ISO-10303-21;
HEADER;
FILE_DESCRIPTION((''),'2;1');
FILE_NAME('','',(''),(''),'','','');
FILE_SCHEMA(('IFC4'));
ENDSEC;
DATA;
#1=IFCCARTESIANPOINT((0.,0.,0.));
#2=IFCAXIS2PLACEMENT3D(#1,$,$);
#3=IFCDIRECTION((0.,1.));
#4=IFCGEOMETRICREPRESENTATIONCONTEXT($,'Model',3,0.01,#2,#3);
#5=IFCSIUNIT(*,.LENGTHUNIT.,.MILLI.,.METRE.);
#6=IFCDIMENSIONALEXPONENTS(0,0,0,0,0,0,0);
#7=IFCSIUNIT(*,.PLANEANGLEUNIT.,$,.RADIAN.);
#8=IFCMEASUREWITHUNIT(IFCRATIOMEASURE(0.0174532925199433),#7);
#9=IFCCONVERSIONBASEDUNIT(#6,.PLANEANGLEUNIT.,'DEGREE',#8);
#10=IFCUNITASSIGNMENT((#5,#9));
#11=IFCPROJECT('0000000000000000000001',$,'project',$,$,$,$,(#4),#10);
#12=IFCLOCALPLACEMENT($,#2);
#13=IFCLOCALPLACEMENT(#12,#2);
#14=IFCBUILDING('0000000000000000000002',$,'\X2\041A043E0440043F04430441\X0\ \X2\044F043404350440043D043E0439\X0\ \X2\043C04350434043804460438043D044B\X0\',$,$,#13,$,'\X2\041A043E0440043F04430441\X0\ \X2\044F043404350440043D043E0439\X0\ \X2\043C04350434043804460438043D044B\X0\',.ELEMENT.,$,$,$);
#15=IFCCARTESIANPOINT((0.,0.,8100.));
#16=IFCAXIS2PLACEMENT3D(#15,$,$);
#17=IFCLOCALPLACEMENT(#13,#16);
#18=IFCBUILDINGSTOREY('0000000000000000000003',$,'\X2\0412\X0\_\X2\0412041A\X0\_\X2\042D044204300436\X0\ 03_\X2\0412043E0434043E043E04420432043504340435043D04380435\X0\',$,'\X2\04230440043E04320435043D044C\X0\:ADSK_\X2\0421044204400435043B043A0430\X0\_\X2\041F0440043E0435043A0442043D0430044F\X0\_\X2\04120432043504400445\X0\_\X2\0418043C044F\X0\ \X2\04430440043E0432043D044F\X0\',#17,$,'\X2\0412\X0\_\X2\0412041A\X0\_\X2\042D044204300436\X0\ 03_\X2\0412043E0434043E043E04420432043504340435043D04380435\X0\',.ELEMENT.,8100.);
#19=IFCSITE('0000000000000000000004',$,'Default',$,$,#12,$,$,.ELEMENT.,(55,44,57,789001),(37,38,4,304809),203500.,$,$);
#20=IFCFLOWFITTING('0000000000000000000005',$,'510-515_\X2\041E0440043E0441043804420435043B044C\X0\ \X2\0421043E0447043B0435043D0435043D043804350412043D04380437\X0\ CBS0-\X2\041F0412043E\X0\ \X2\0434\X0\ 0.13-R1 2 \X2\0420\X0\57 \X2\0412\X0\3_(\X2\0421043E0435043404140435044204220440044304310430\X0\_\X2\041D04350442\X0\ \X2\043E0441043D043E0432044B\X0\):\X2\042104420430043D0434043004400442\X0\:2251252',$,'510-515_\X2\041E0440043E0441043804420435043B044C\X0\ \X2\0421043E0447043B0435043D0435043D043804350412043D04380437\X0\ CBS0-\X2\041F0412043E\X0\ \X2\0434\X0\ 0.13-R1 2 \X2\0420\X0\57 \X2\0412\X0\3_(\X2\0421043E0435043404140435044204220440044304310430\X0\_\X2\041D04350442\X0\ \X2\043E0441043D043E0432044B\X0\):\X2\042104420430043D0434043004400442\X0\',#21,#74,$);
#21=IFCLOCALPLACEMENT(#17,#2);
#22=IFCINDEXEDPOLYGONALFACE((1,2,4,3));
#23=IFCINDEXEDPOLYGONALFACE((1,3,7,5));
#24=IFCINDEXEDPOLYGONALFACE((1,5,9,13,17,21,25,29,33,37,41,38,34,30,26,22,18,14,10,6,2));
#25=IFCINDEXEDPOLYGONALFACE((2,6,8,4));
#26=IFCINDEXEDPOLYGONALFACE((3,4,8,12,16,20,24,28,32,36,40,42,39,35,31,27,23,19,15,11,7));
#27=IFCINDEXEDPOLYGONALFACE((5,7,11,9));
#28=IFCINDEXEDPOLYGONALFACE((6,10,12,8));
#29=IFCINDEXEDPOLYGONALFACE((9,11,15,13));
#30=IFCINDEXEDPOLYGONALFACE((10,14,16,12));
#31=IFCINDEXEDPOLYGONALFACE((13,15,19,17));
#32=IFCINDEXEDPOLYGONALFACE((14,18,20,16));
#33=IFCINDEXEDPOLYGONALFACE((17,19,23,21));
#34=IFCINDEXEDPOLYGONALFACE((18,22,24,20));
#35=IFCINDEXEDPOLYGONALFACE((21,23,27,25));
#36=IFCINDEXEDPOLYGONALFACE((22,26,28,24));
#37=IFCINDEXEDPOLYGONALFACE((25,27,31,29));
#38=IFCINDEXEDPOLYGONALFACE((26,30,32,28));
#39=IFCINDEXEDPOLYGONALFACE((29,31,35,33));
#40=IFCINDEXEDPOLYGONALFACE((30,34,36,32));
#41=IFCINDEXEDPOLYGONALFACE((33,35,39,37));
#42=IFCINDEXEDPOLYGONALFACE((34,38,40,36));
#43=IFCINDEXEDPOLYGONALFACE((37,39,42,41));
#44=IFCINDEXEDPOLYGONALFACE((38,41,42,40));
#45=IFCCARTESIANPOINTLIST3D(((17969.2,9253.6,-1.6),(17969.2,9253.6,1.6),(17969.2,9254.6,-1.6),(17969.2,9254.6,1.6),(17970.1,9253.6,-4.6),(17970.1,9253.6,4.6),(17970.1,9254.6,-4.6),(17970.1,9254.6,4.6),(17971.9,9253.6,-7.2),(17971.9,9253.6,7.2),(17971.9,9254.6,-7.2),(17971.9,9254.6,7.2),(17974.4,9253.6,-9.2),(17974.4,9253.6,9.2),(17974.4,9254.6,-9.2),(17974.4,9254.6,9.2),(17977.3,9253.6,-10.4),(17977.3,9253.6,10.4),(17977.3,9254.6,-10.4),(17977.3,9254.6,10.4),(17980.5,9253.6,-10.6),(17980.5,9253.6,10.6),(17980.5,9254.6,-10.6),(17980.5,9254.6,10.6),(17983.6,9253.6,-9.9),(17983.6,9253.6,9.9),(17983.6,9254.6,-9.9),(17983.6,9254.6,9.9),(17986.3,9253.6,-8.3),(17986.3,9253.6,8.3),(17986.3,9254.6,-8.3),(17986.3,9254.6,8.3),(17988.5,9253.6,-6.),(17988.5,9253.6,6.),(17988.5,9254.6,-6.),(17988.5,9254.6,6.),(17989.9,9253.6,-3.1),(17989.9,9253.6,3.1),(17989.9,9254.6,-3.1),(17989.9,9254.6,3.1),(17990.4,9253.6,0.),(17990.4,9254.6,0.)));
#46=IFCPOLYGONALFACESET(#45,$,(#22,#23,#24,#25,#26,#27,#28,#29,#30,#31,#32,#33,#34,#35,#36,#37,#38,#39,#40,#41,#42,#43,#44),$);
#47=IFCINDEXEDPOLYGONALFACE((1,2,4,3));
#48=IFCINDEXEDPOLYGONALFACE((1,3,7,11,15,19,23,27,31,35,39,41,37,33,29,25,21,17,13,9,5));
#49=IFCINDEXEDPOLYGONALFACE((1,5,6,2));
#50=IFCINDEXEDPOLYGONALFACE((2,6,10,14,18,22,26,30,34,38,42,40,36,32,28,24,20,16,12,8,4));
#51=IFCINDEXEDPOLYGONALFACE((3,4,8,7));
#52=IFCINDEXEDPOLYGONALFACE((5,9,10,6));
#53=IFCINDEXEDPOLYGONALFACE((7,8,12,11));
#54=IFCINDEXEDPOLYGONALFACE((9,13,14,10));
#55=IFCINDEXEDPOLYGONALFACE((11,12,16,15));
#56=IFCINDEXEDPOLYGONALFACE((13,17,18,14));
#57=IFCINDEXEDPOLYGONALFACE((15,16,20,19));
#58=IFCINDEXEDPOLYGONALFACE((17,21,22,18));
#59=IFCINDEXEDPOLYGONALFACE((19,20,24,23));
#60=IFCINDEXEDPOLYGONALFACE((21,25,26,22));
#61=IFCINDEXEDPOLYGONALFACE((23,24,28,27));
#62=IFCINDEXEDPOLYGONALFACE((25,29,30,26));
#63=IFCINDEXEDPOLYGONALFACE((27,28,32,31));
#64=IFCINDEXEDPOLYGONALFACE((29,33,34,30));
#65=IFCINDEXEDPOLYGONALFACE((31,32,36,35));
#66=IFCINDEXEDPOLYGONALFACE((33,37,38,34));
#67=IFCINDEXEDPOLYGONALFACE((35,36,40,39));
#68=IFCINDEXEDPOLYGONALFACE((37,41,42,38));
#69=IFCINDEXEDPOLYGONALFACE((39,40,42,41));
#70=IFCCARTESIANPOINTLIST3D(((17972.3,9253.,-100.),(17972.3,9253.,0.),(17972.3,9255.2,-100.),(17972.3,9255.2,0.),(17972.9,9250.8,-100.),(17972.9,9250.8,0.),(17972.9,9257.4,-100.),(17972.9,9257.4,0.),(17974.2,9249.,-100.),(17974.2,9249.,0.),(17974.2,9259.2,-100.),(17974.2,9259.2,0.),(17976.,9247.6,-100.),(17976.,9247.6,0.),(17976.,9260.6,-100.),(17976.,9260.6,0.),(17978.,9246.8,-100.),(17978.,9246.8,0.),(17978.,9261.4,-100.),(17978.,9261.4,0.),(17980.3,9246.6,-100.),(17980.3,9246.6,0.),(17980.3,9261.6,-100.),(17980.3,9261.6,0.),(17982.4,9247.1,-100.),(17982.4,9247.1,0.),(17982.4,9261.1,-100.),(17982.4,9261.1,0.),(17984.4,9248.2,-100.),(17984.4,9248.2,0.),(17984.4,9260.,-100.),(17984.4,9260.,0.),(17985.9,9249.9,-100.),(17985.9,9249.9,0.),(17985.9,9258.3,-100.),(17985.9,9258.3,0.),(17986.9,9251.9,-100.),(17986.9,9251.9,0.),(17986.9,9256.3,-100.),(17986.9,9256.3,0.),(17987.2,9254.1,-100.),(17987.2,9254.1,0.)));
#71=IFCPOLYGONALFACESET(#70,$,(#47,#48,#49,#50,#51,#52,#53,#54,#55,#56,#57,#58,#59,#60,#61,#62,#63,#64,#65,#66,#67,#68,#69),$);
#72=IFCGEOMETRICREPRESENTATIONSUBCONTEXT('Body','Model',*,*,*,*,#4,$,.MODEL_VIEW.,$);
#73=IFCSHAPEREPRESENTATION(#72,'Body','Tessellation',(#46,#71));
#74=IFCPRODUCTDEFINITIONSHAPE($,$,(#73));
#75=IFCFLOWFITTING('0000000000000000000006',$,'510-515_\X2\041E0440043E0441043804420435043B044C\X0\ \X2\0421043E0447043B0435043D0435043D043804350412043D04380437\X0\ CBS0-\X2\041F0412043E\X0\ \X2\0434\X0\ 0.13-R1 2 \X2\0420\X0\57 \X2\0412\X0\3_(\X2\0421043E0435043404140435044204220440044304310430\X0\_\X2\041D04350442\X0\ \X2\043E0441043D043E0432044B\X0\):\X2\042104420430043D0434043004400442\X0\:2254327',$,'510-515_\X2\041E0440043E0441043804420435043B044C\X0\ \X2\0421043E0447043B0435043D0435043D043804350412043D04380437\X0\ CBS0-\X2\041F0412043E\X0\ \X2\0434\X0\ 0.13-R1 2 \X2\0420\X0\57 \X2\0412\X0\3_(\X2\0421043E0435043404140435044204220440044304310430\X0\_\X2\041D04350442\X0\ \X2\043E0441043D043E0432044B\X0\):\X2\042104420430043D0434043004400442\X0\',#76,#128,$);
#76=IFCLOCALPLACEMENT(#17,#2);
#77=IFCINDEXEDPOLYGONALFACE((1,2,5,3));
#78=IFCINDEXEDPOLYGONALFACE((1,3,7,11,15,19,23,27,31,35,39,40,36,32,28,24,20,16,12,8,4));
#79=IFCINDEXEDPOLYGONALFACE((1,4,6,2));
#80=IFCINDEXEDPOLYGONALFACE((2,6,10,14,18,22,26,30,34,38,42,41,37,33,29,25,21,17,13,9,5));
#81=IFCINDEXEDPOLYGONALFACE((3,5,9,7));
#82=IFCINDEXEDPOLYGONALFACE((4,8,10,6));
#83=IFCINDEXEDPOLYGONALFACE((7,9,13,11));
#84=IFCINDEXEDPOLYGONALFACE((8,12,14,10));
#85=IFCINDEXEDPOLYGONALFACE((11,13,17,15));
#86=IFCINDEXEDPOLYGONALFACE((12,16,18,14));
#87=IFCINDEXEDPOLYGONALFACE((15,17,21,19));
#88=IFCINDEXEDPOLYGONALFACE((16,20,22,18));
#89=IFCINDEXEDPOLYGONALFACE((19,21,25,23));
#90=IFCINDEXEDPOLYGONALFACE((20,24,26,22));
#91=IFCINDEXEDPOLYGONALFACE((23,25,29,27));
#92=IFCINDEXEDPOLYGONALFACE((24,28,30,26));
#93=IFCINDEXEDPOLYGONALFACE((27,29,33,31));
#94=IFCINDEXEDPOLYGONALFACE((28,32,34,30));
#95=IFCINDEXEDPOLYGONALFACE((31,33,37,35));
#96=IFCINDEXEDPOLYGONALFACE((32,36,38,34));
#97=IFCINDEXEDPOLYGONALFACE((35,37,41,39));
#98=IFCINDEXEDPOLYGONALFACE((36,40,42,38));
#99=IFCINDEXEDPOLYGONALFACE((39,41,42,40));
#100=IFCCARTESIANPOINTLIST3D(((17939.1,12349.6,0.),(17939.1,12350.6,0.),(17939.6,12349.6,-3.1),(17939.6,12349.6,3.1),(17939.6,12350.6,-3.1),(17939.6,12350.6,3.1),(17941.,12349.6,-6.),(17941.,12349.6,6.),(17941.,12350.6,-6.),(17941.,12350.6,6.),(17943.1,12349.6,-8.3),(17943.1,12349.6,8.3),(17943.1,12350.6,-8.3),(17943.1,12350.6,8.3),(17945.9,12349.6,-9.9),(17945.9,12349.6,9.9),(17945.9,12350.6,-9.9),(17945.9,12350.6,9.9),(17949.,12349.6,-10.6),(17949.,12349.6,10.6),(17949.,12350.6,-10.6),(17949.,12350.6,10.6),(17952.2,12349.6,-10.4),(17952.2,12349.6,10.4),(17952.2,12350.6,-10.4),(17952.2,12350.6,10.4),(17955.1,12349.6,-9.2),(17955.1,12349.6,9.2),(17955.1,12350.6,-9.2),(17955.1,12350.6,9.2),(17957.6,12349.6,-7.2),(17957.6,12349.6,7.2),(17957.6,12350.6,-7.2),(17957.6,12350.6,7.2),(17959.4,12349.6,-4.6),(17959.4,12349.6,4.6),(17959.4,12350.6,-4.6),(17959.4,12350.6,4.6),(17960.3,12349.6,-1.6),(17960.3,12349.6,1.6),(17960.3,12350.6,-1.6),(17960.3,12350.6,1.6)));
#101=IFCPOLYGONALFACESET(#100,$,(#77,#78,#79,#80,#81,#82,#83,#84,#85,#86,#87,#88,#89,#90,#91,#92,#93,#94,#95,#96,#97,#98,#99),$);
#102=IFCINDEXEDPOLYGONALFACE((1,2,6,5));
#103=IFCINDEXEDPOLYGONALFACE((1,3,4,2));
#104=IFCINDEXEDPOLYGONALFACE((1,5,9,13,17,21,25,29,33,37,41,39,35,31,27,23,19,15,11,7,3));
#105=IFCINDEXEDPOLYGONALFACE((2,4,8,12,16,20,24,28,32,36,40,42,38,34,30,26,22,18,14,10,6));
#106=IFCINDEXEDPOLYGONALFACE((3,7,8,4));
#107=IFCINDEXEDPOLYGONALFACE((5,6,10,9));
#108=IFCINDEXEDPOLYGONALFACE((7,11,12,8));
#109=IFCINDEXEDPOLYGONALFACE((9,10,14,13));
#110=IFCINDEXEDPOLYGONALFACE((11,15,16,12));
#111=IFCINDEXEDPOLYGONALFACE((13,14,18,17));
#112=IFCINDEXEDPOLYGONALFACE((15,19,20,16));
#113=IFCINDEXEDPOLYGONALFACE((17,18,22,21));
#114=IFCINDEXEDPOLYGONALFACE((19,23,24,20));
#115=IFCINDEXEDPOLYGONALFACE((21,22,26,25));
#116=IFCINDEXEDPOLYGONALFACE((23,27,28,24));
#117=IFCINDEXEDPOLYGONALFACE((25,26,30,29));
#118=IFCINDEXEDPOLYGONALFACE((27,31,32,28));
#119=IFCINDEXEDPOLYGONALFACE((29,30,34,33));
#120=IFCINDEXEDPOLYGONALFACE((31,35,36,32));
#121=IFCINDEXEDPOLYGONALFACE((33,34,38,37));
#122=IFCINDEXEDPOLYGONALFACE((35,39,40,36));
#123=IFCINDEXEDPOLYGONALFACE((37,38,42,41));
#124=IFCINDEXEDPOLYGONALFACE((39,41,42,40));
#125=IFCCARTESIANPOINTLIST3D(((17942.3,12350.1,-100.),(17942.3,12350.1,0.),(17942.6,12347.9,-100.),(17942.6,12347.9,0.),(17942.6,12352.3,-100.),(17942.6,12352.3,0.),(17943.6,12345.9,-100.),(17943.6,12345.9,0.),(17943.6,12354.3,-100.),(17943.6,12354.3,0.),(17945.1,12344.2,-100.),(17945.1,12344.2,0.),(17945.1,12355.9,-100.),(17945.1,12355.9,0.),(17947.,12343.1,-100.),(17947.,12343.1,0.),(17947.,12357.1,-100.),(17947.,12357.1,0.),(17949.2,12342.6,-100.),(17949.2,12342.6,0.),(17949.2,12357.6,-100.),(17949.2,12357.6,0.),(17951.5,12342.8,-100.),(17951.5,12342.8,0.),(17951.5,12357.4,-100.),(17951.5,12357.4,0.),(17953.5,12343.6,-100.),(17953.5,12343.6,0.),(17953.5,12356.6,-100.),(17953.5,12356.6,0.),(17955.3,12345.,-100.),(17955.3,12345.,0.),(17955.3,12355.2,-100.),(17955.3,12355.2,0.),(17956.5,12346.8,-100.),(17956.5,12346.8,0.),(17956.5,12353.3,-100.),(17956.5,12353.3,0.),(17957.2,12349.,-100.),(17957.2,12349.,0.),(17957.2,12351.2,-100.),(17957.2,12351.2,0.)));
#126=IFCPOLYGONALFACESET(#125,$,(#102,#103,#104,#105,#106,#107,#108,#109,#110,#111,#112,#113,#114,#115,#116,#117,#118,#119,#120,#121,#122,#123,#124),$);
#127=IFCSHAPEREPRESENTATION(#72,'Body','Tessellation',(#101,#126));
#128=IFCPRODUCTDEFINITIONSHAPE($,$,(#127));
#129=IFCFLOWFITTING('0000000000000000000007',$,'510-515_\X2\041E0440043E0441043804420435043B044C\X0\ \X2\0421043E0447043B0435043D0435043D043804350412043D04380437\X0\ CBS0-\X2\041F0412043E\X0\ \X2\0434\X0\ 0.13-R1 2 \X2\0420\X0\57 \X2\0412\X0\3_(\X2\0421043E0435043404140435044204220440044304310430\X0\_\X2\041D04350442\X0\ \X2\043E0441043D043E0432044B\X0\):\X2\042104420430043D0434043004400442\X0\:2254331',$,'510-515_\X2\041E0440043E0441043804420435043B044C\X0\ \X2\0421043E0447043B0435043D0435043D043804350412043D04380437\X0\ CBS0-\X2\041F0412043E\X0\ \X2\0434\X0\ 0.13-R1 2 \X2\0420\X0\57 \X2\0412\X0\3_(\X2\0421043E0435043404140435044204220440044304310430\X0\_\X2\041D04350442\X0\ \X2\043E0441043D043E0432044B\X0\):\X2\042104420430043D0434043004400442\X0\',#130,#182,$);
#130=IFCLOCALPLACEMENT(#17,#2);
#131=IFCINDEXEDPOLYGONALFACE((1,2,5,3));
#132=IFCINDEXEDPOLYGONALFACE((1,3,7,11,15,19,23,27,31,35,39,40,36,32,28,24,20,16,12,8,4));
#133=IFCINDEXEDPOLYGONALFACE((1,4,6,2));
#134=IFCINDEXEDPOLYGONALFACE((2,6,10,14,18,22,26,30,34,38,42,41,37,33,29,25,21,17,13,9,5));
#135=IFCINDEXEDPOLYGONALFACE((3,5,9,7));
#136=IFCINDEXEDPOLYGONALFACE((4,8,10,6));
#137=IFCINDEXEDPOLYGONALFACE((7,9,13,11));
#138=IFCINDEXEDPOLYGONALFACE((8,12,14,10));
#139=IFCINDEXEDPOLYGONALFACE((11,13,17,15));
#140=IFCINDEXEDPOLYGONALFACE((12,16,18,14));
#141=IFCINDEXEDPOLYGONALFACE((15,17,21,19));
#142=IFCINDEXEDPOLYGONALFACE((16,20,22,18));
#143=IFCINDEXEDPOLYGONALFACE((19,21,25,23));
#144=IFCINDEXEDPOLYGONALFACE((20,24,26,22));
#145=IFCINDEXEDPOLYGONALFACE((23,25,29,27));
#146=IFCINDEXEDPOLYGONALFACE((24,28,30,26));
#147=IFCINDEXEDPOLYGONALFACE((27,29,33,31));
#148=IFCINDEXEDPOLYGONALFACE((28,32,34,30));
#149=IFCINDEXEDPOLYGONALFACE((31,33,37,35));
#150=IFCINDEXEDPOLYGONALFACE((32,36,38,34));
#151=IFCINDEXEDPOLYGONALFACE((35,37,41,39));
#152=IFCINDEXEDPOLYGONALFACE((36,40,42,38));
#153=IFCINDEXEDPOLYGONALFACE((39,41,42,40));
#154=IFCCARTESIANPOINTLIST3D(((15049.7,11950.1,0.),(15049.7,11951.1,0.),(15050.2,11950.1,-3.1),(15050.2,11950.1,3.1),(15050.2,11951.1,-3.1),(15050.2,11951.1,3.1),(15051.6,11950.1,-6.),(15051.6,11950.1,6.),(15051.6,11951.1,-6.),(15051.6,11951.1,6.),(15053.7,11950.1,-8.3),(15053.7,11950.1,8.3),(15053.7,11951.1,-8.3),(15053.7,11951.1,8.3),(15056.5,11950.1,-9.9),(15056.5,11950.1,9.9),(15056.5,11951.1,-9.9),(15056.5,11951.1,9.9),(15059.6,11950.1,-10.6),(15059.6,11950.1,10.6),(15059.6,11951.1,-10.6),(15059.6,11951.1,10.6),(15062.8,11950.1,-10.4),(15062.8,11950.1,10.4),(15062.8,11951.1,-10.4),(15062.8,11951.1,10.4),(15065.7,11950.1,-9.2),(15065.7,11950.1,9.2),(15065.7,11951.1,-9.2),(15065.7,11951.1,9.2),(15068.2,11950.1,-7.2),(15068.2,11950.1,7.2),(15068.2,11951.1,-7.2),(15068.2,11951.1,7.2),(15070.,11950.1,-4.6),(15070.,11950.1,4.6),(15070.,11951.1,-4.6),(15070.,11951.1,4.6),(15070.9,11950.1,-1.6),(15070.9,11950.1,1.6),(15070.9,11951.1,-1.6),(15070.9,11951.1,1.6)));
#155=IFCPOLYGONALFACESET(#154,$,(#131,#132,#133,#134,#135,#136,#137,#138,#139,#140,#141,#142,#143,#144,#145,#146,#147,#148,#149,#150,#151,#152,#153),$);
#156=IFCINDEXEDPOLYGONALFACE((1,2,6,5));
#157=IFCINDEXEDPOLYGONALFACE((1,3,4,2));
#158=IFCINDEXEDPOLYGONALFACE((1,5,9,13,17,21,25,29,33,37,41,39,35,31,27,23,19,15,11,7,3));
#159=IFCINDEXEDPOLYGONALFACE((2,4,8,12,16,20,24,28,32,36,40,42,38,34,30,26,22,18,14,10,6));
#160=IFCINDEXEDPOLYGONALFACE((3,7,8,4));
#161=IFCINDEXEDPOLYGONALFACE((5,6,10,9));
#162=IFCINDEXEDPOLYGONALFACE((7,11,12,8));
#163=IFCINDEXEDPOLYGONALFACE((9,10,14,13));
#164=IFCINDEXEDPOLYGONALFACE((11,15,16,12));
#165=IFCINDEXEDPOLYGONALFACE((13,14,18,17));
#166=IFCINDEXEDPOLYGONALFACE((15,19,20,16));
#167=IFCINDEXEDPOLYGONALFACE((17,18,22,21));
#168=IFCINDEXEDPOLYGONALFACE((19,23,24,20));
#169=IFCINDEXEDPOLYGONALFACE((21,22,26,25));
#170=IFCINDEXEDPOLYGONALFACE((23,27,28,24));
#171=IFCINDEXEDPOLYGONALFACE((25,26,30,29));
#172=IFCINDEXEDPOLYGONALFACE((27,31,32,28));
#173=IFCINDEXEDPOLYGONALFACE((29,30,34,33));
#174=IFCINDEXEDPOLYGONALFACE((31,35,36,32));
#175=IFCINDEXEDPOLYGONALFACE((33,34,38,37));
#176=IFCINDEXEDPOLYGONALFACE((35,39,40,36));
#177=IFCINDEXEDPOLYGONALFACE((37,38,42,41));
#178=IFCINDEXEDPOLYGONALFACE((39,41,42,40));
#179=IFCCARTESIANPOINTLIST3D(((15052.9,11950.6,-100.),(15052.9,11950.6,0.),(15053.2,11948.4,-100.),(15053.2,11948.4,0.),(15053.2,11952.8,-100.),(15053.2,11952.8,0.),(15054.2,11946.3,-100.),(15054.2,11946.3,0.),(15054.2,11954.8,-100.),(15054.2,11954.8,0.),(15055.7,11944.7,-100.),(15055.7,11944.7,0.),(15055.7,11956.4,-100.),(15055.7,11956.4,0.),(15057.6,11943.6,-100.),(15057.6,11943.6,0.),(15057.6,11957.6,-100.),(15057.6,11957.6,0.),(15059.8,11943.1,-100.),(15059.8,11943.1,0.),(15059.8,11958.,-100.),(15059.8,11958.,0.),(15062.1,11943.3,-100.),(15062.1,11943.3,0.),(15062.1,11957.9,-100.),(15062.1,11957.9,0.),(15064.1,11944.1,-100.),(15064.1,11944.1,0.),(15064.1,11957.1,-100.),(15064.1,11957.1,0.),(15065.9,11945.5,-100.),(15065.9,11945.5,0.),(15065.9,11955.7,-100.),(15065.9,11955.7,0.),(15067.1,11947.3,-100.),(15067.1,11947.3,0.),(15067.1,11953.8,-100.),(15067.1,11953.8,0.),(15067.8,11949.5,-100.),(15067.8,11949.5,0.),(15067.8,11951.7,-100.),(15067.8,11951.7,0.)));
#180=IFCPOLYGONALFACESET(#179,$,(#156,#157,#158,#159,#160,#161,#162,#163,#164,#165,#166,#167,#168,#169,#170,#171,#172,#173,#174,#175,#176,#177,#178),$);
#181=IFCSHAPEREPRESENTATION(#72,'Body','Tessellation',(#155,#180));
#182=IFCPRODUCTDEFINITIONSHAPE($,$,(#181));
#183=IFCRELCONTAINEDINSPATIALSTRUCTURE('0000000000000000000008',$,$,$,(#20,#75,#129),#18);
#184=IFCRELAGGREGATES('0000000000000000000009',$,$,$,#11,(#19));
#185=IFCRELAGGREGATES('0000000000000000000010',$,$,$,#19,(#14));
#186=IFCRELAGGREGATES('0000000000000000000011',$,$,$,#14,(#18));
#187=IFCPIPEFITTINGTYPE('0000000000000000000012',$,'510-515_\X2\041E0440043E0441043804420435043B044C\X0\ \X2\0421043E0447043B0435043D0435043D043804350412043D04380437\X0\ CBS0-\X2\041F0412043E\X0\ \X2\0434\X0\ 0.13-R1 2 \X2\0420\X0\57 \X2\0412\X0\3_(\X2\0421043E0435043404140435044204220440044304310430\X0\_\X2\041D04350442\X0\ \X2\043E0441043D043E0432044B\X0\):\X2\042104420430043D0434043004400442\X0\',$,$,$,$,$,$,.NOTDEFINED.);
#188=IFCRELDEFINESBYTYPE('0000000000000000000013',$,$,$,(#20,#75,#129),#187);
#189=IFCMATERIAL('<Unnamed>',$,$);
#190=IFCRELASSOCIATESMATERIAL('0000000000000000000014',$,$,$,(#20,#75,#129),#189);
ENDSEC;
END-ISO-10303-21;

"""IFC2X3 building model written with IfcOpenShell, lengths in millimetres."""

from ifc_helpers import new_model, entity, si_unit, converted_unit, direction, frame, origin, origin_2d_with_axis, place, context, subcontext, project, spatial, circle, extrude, source, transform, mapped, material, type_object, type_shapes, element, save


model = new_model("IFC2X3")

# Units and contexts
model_context = context("Model", 3, precision=0.01, world=origin(), true_north=direction((0.0, 1.0)))
body_context = subcontext(model_context, "Body", "Model", "MODEL_VIEW")
ifc_project = project(units=[si_unit("LENGTHUNIT", "METRE", prefix="MILLI"), converted_unit("PLANEANGLEUNIT", "DEGREE", entity("IfcRatioMeasure", 0.0174532925199433), si_unit("PLANEANGLEUNIT", "RADIAN"), dimensions=[0, 0, 0, 0, 0, 0, 0])], contexts=[model_context])

# Site, building, storey
site_placement = place(None, origin())
site = spatial("IfcSite", under=ifc_project, at=site_placement, Name="Default", CompositionType="ELEMENT", RefLatitude=(55, 44, 57, 789001), RefLongitude=(37, 38, 4, 304809), RefElevation=203500.0)
building_placement = place(site_placement, origin())
building = spatial("IfcBuilding", under=site, at=building_placement, Name="Корпус ядерной медицины", LongName="Корпус ядерной медицины", CompositionType="ELEMENT")
storey_placement = place(building_placement, frame((0.0, 0.0, 8100.0)))
storey = spatial("IfcBuildingStorey", under=building, at=storey_placement, Name="В_ВК_Этаж 03_Водоотведение", ObjectType="Уровень:ADSK_Стрелка_Проектная_Вверх_Имя уровня", LongName="В_ВК_Этаж 03_Водоотведение", CompositionType="ELEMENT", Elevation=8100.0)

# Flow fittings
ifc_material_1 = material(Name="<Unnamed>")
pipe_fitting_type_1 = type_object("IfcPipeFittingType", Name="510-515_Ороситель СочленениеВниз CBS0-ПВо д 0.13-R1 2 Р57 В3_(СоедДетТруба_Нет основы):Стандарт", PredefinedType="NOTDEFINED")
shared_shape_1 = source(origin(), body_context, "Body", "SweptSolid", [
    extrude(circle(Radius=10.7, at=origin_2d_with_axis()), frame((-0.5, 0.0, 0.0), z_axis=(1.0, 0.0, 0.0), x_axis=(0.0, 1.0, 0.0)), (0.0, 0.0, 1.0), 1.0),
    extrude(circle(Radius=7.5, at=origin_2d_with_axis()), frame((0.0, 0.0, -100.0), z_axis=(0.0, 0.0, 1.0), x_axis=(0.0, 1.0, 0.0)), (0.0, 0.0, 1.0), 100.0),
])
type_shapes(pipe_fitting_type_1, [shared_shape_1])
for number, where, z_axis, x_axis, name in (
    (1, (17979.7, 9254.1, 0.0), (0.0, 0.0, 1.0), (0.0, -1.0, 0.0), "510-515_Ороситель СочленениеВниз CBS0-ПВо д 0.13-R1 2 Р57 В3_(СоедДетТруба_Нет основы):Стандарт:2251252"),
    (2, (17949.8, 12350.1, 0.0), (0.0, 0.0, 1.0), (0.0, 1.0, 0.0), "510-515_Ороситель СочленениеВниз CBS0-ПВо д 0.13-R1 2 Р57 В3_(СоедДетТруба_Нет основы):Стандарт:2254327"),
    (3, (15060.4, 11950.6, 0.0), (0.0, 0.0, 1.0), (0.0, 1.0, 0.0), "510-515_Ороситель СочленениеВниз CBS0-ПВо д 0.13-R1 2 Р57 В3_(СоедДетТруба_Нет основы):Стандарт:2254331"),
):
    element("IfcFlowFitting", number, at=place(storey_placement, frame(where, z_axis=z_axis, x_axis=x_axis)), inside=storey, type_object=pipe_fitting_type_1, material=ifc_material_1, Name=name, ObjectType="510-515_Ороситель СочленениеВниз CBS0-ПВо д 0.13-R1 2 Р57 В3_(СоедДетТруба_Нет основы):Стандарт", context=body_context, shape_type="MappedRepresentation", body=[
        mapped(shared_shape_1, transform((0.0, 0.0, 0.0), scale=1.0)),
    ])

save(model, "model.ifc")
